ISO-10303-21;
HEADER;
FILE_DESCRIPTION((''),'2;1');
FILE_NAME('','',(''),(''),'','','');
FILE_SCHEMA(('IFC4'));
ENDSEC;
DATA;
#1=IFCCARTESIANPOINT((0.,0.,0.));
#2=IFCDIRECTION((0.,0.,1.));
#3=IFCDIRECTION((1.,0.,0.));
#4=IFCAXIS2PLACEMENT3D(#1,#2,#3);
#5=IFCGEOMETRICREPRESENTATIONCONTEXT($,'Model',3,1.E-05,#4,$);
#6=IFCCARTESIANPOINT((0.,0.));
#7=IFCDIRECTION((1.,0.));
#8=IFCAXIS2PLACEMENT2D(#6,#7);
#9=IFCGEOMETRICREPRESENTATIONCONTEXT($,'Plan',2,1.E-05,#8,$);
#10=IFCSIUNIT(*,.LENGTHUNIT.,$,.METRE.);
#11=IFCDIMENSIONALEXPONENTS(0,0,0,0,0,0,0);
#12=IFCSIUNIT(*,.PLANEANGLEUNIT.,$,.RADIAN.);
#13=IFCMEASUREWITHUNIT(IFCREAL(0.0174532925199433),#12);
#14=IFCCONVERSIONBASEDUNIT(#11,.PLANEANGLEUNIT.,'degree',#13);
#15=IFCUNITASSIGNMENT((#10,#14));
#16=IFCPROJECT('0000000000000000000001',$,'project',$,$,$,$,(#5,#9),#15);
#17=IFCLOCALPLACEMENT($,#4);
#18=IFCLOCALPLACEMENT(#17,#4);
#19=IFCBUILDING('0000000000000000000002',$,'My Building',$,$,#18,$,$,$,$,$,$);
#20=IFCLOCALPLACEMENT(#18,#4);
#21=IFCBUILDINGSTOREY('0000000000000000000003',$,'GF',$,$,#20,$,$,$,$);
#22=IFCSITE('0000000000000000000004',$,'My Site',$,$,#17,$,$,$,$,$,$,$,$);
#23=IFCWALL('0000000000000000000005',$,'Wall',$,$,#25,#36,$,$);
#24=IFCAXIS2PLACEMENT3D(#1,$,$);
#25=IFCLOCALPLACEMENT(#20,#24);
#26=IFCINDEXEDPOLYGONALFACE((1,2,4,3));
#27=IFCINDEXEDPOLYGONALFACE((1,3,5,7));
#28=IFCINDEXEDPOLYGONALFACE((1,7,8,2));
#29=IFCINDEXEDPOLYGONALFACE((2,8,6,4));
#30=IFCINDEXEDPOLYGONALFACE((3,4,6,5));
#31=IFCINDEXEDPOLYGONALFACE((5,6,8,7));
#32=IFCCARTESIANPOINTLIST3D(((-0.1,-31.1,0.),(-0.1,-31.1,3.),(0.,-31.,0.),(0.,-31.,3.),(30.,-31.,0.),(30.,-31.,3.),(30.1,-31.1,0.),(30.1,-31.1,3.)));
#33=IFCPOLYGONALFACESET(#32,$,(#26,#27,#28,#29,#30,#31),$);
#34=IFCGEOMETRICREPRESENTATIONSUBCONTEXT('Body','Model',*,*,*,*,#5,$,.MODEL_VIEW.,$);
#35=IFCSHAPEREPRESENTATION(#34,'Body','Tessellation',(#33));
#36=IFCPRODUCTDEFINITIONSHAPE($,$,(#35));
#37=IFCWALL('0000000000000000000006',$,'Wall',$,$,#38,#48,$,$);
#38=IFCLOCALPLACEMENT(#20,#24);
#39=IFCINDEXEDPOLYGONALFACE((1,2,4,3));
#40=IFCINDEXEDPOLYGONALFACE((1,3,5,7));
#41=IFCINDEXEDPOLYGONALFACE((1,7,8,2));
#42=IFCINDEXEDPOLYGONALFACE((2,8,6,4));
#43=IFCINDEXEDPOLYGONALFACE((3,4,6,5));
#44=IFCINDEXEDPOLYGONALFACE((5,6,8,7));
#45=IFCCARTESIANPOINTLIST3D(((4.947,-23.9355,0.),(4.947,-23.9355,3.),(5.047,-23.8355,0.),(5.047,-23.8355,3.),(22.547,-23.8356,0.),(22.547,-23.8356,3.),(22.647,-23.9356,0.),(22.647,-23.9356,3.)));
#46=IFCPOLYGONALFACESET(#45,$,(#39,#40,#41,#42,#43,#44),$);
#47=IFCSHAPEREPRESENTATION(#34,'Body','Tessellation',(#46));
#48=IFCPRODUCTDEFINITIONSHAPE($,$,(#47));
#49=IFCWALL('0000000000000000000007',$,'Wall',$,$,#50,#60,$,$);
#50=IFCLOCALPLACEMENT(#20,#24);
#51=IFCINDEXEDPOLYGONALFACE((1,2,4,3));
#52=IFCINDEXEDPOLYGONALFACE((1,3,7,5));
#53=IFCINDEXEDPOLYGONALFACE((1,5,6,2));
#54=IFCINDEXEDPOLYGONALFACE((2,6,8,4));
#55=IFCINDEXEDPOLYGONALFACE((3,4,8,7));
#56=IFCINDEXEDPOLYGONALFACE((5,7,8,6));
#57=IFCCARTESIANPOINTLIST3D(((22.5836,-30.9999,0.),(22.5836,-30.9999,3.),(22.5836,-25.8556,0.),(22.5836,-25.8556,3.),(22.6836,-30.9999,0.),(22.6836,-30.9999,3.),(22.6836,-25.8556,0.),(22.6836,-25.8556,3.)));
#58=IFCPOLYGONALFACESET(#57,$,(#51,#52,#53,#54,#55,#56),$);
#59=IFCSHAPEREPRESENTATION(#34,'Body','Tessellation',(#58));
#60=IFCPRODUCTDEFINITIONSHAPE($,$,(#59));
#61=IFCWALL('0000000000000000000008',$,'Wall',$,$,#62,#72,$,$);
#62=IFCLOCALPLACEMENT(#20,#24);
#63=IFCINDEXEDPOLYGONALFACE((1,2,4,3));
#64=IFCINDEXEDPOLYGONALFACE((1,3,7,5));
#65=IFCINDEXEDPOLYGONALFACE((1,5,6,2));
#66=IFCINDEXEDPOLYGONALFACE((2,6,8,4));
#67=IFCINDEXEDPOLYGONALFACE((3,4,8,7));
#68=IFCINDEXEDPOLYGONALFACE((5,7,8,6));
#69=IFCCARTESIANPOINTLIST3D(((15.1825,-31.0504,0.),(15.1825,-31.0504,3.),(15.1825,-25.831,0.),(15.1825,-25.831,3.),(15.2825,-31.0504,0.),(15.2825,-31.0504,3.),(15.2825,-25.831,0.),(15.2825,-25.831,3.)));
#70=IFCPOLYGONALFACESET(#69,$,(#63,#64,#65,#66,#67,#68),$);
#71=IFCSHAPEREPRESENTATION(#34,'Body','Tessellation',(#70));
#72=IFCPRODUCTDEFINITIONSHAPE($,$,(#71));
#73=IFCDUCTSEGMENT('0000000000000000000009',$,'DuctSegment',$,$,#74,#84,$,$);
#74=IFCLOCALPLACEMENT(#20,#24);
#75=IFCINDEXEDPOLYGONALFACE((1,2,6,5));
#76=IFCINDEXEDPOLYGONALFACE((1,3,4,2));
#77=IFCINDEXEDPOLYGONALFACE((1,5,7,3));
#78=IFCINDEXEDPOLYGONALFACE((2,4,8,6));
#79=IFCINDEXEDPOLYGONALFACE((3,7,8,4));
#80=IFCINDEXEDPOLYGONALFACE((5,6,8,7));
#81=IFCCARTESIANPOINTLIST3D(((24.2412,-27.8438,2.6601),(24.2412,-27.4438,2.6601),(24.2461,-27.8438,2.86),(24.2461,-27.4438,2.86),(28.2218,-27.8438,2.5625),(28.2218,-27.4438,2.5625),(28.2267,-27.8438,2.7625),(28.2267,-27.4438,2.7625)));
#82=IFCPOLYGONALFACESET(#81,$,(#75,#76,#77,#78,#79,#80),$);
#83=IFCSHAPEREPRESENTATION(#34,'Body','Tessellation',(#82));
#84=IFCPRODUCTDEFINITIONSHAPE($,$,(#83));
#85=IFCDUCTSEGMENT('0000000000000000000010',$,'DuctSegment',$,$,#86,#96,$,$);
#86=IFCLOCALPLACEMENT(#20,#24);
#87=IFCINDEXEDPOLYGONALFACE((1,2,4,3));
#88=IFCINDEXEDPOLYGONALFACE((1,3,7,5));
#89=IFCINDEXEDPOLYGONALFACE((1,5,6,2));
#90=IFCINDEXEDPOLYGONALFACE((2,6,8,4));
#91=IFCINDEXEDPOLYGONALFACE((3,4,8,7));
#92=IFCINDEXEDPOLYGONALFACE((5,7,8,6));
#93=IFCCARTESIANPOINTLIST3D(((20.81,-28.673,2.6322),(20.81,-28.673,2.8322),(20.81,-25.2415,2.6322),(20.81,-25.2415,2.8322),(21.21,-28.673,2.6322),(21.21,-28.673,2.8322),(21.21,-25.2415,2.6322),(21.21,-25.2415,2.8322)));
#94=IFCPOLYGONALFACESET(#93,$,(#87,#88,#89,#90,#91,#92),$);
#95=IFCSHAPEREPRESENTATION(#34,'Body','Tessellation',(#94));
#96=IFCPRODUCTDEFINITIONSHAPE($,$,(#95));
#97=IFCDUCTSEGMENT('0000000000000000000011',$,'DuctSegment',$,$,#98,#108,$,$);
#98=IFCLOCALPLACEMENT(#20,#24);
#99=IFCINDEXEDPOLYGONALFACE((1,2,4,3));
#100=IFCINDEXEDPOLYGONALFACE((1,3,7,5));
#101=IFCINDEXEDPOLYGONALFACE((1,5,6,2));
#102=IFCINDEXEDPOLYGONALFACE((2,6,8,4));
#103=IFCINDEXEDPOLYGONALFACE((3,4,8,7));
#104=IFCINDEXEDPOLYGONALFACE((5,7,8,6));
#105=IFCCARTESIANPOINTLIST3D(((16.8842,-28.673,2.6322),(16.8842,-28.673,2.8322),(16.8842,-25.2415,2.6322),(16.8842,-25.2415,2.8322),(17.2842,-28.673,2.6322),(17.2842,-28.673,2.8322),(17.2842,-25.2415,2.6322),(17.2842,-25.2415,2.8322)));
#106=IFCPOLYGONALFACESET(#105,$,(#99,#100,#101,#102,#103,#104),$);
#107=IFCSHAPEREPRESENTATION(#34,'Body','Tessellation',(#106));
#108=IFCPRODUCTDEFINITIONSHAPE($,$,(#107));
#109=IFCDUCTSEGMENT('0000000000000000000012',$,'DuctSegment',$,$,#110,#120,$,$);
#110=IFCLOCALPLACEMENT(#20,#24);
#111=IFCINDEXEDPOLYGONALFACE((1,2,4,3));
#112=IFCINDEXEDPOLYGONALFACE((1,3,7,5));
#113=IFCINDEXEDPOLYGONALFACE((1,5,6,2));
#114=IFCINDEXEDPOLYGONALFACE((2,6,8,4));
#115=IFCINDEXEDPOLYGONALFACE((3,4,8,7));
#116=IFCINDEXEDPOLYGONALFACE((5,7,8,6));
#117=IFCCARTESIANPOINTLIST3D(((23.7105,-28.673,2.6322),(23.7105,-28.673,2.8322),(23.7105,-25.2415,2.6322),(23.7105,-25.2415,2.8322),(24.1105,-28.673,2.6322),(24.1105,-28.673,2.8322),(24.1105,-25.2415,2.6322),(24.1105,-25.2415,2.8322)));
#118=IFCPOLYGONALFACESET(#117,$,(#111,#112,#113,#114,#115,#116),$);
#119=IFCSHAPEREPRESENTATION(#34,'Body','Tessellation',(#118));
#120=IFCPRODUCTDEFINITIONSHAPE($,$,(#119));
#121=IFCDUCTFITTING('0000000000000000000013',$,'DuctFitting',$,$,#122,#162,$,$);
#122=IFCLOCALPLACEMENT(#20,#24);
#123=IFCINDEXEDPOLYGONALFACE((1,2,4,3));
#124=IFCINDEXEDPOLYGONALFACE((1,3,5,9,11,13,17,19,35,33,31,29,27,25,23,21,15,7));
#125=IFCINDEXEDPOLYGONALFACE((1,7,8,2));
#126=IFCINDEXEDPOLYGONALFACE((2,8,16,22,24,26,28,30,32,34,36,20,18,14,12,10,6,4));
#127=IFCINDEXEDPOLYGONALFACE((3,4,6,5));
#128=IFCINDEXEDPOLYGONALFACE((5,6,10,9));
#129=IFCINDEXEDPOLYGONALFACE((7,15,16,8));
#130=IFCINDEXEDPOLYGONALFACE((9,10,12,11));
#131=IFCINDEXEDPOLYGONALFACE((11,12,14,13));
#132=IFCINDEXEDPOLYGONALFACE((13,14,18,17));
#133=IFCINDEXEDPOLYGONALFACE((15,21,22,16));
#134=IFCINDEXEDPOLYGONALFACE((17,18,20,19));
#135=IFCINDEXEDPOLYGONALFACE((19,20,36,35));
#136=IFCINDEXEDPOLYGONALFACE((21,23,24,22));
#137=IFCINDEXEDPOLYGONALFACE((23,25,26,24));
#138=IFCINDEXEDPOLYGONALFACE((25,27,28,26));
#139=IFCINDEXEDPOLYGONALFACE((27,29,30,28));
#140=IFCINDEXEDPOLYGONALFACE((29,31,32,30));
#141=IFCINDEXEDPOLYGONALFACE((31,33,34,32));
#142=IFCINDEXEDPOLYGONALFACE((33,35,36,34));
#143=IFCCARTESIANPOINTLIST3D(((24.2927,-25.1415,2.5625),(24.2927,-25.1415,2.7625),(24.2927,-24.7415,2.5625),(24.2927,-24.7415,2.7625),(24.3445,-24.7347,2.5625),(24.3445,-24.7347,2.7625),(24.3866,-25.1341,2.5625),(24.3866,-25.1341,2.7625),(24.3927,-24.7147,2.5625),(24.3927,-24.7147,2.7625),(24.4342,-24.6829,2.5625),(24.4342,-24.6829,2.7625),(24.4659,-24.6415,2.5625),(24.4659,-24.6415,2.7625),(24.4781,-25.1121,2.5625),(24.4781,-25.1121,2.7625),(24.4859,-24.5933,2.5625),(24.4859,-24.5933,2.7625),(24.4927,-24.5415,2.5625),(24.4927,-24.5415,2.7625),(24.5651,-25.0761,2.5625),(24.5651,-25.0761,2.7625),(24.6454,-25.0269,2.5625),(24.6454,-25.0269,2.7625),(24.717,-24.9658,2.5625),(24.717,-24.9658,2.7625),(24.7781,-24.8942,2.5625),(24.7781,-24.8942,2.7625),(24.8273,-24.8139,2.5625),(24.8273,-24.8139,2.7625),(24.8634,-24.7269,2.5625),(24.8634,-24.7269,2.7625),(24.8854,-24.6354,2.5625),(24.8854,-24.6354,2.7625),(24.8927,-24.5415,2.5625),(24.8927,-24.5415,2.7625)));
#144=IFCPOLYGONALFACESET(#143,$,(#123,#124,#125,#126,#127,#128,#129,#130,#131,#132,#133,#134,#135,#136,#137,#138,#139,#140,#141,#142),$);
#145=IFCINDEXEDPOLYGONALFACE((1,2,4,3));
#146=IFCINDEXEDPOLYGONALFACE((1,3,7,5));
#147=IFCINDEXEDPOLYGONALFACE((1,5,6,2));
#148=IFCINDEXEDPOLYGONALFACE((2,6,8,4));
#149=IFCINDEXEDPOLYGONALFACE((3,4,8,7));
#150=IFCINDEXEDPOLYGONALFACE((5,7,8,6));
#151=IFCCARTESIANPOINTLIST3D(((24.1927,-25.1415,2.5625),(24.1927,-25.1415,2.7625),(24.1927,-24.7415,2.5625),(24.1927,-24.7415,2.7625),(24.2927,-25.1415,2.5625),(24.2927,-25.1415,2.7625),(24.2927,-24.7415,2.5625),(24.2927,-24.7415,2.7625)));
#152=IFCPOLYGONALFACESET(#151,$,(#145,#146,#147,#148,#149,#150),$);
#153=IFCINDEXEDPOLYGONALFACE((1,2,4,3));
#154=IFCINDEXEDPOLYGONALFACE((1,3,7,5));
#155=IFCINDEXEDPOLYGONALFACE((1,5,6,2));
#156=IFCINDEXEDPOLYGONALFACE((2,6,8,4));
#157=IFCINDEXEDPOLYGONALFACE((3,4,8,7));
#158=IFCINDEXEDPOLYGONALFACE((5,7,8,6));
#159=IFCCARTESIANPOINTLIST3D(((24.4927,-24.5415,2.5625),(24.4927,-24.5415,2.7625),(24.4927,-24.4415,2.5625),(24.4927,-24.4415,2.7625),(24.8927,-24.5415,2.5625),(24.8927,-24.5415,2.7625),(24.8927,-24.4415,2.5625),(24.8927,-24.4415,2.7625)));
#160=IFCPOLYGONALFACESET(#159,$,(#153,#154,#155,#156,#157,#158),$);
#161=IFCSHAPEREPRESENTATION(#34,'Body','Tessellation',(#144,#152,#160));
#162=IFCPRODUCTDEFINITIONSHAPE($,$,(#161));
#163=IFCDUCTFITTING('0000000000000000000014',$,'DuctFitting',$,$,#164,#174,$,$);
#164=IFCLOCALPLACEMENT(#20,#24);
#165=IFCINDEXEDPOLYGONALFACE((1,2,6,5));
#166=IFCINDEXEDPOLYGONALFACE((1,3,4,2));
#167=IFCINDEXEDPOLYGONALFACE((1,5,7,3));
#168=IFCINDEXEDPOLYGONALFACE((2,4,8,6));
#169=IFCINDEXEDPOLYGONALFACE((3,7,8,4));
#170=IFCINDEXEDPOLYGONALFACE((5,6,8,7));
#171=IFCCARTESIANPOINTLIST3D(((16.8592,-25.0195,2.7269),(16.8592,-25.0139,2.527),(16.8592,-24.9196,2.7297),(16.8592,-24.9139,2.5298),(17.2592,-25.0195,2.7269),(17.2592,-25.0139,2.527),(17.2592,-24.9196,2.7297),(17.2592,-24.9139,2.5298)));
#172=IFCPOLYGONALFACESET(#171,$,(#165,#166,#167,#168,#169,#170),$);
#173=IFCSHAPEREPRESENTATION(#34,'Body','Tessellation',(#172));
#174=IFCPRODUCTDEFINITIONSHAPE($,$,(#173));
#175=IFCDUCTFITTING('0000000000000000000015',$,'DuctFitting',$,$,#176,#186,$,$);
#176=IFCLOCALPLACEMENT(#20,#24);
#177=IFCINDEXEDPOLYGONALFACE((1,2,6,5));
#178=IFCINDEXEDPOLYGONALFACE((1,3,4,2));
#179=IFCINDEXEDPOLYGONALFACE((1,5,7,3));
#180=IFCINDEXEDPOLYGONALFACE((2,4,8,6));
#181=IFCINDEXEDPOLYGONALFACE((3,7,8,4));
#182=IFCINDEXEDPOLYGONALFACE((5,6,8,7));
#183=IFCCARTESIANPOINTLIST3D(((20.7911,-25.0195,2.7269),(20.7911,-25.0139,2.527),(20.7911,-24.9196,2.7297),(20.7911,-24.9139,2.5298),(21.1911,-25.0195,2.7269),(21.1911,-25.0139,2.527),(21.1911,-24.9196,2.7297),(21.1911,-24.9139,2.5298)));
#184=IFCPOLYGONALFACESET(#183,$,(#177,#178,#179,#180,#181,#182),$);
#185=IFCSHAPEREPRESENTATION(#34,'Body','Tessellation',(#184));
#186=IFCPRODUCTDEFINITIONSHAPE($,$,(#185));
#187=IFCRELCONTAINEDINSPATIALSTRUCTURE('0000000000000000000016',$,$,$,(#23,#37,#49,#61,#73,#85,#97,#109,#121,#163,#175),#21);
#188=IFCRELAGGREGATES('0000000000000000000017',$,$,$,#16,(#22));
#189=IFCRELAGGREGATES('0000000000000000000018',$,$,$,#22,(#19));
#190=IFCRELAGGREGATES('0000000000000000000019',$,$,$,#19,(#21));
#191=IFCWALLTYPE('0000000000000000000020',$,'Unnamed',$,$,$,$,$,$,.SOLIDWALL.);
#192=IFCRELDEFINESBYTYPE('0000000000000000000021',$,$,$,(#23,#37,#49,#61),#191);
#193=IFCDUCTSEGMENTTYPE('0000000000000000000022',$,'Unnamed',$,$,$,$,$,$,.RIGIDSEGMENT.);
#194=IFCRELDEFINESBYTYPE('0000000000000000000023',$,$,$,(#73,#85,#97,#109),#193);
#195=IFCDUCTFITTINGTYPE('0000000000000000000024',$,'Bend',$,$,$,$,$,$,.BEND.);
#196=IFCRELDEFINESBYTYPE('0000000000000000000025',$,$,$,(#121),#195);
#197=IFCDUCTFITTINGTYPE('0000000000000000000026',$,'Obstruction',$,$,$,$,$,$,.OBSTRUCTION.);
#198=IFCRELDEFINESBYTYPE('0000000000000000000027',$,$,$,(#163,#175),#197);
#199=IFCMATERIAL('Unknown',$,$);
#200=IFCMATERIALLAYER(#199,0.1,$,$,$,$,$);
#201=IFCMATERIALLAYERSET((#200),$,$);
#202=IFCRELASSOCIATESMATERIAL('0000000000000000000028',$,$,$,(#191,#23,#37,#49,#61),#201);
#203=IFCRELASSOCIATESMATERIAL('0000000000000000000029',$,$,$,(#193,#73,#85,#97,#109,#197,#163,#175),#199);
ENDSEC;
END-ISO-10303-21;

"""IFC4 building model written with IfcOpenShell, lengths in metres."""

from ifc_helpers import new_model, entity, si_unit, converted_unit, frame, origin_with_axes, origin_2d_with_axis, place, context, subcontext, project, spatial, line, arc, indexed_curve, rectangle, outline, extrude, source, transform, mapped, material, layer, layer_set, layer_usage, material_profile, profile_set, profile_usage, type_object, type_shapes, element, save


model = new_model("IFC4")

# Units and contexts
model_context = context("Model", 3, precision=1e-05, world=origin_with_axes())
plan_context = context("Plan", 2, precision=1e-05, world=origin_2d_with_axis())
body_context = subcontext(model_context, "Body", "Model", "MODEL_VIEW")
ifc_project = project(units=[si_unit("LENGTHUNIT", "METRE"), converted_unit("PLANEANGLEUNIT", "degree", entity("IfcReal", 0.0174532925199433), si_unit("PLANEANGLEUNIT", "RADIAN"), dimensions=[0, 0, 0, 0, 0, 0, 0])], contexts=[model_context, plan_context])

# Site, building, storey
site_placement = place(None, origin_with_axes())
site = spatial("IfcSite", under=ifc_project, at=site_placement, Name="My Site")
building_placement = place(site_placement, origin_with_axes())
building = spatial("IfcBuilding", under=site, at=building_placement, Name="My Building")
storey_placement = place(building_placement, origin_with_axes())
storey = spatial("IfcBuildingStorey", under=building, at=storey_placement, Name="GF")

# Walls
ifc_material = material(Name="Unknown")
ifc_layer = layer(ifc_material, 0.1)
ifc_layer_set = layer_set([ifc_layer])
ifc_layer_usage_1 = layer_usage(ifc_layer_set, "AXIS2", "POSITIVE", 0.0)
wall_type = type_object("IfcWallType", Name="Unnamed", PredefinedType="SOLIDWALL", material=ifc_layer_set)
wall_1_placement = place(storey_placement, frame((30.0, -31.0, 0.0), z_axis=(0.0, 0.0, 1.0), x_axis=(-1.0, 0.0, 0.0)))
element("IfcWall", 1, at=wall_1_placement, inside=storey, type_object=wall_type, material=ifc_layer_usage_1, Name="Wall", context=body_context, shape_type="SweptSolid", body=[
    extrude(outline(indexed_curve([(0.0, 0.0), (-0.1, 0.1), (30.1, 0.1), (30.0, 0.0)], segments=[line(1, 2, 3, 4, 1)])), origin_with_axes(), (0.0, 0.0, 1.0), 3.0),
])
ifc_layer_usage_2 = layer_usage(ifc_layer_set, "AXIS2", "POSITIVE", 0.0)
wall_2_placement = place(storey_placement, frame((22.547, -23.8356, 0.0), z_axis=(0.0, 0.0, 1.0), x_axis=(-1.0, 0.0, 0.0)))
element("IfcWall", 2, at=wall_2_placement, inside=storey, type_object=wall_type, material=ifc_layer_usage_2, Name="Wall", context=body_context, shape_type="SweptSolid", body=[
    extrude(outline(indexed_curve([(0.0, 0.0), (-0.1, 0.1), (17.6, 0.1), (17.5, 0.0)], segments=[line(1, 2, 3, 4, 1)])), origin_with_axes(), (0.0, 0.0, 1.0), 3.0),
])
ifc_layer_usage_3 = layer_usage(ifc_layer_set, "AXIS2", "POSITIVE", 0.0)
wall_3_placement = place(storey_placement, frame((22.5836, -25.8556, 0.0), z_axis=(0.0, 0.0, 1.0), x_axis=(0.0, -1.0, 0.0)))
element("IfcWall", 3, at=wall_3_placement, inside=storey, type_object=wall_type, material=ifc_layer_usage_3, Name="Wall", context=body_context, shape_type="SweptSolid", body=[
    extrude(outline(indexed_curve([(0.0, 0.0), (0.0, 0.1), (5.1443, 0.1), (5.1443, 0.0)], segments=[line(1, 2, 3, 4, 1)])), origin_with_axes(), (0.0, 0.0, 1.0), 3.0),
])
ifc_layer_usage_4 = layer_usage(ifc_layer_set, "AXIS2", "POSITIVE", 0.0)
wall_4_placement = place(storey_placement, frame((15.1825, -25.831, 0.0), z_axis=(0.0, 0.0, 1.0), x_axis=(0.0, -1.0, 0.0)))
element("IfcWall", 4, at=wall_4_placement, inside=storey, type_object=wall_type, material=ifc_layer_usage_4, Name="Wall", context=body_context, shape_type="SweptSolid", body=[
    extrude(outline(indexed_curve([(0.0, 0.0), (0.0, 0.1), (5.2194, 0.1), (5.2194, 0.0)], segments=[line(1, 2, 3, 4, 1)])), origin_with_axes(), (0.0, 0.0, 1.0), 3.0),
])

# Duct segments
ifc_material_profile_1 = material_profile(ifc_material, rectangle(XDim=0.4, YDim=0.2))
ifc_profile_set_1 = profile_set([ifc_material_profile_1])
ifc_profile_usage_1 = profile_usage(ifc_profile_set_1, cardinal=5)
duct_segment_type = type_object("IfcDuctSegmentType", Name="Unnamed", PredefinedType="RIGIDSEGMENT", material=ifc_profile_set_1)
duct_segment_1_placement = place(storey_placement, frame((24.2437, -27.6438, 2.7601), z_axis=(0.9997, 0.0, -0.024499), x_axis=(0.0, 1.0, 0.0)))
element("IfcDuctSegment", 5, at=duct_segment_1_placement, inside=storey, type_object=duct_segment_type, material=ifc_profile_usage_1, Name="DuctSegment", context=body_context, shape_type="SweptSolid", body=[
    extrude(rectangle(XDim=0.4, YDim=0.2), origin_with_axes(), (0.0, 0.0, 1.0), 3.9818),
])
ifc_profile_usage_2 = profile_usage(ifc_profile_set_1, cardinal=5)
duct_segment_2_placement = place(storey_placement, frame((21.01, -25.2415, 2.7322), z_axis=(0.0, -1.0, 0.0), x_axis=(1.0, 0.0, 0.0)))
element("IfcDuctSegment", 6, at=duct_segment_2_placement, inside=storey, type_object=duct_segment_type, material=ifc_profile_usage_2, Name="DuctSegment", context=body_context, shape_type="SweptSolid", body=[
    extrude(rectangle(XDim=0.4, YDim=0.2), origin_with_axes(), (0.0, 0.0, 1.0), 3.4315),
])
ifc_profile_usage_3 = profile_usage(ifc_profile_set_1, cardinal=5)
duct_segment_3_placement = place(storey_placement, frame((17.0842, -25.2415, 2.7322), z_axis=(0.0, -1.0, 0.0), x_axis=(1.0, 0.0, 0.0)))
element("IfcDuctSegment", 7, at=duct_segment_3_placement, inside=storey, type_object=duct_segment_type, material=ifc_profile_usage_3, Name="DuctSegment", context=body_context, shape_type="SweptSolid", body=[
    extrude(rectangle(XDim=0.4, YDim=0.2), origin_with_axes(), (0.0, 0.0, 1.0), 3.4315),
])
ifc_profile_usage_4 = profile_usage(ifc_profile_set_1, cardinal=5)
duct_segment_4_placement = place(storey_placement, frame((23.9105, -25.2415, 2.7322), z_axis=(0.0, -1.0, 0.0), x_axis=(1.0, 0.0, 0.0)))
element("IfcDuctSegment", 8, at=duct_segment_4_placement, inside=storey, type_object=duct_segment_type, material=ifc_profile_usage_4, Name="DuctSegment", context=body_context, shape_type="SweptSolid", body=[
    extrude(rectangle(XDim=0.4, YDim=0.2), origin_with_axes(), (0.0, 0.0, 1.0), 3.4315),
])

# Duct fittings
duct_fitting_type_1 = type_object("IfcDuctFittingType", Name="Bend", PredefinedType="BEND")
shared_shape = source(origin_with_axes(), body_context, "Body", "SweptSolid", [
    extrude(outline(indexed_curve([(0.2, 0.0), (0.2586, -0.1414), (0.4, -0.2), (0.4, -0.6), (-0.0243, -0.4243), (-0.2, 0.0)], segments=[arc(1, 2, 3), line(3, 4), arc(4, 5, 6), line(6, 1)])), frame((0.0, -0.1, -0.1), z_axis=(0.0, -1.0, 0.0), x_axis=(1.0, 0.0, 0.0)), (0.0, 0.0, -1.0), 0.2),
    extrude(rectangle(XDim=0.4, YDim=0.2), origin_with_axes(), (0.0, 0.0, -1.0), 0.1),
    extrude(rectangle(XDim=0.4, YDim=0.2), frame((0.4, 0.0, -0.5), z_axis=(1.0, 0.0, 0.0), x_axis=(0.0, 0.0, 1.0)), (0.0, 0.0, 1.0), 0.1),
])
type_shapes(duct_fitting_type_1, [shared_shape])
duct_fitting_1_placement = place(storey_placement, frame((24.1927, -24.9415, 2.6625), z_axis=(-1.0, 0.0, 0.0), x_axis=(0.0, 1.0, 0.0)))
element("IfcDuctFitting", 9, at=duct_fitting_1_placement, inside=storey, type_object=duct_fitting_type_1, Name="DuctFitting", context=body_context, shape_type="MappedRepresentation", body=[
    mapped(shared_shape, transform((0.0, 0.0, 0.0), x_axis=(1.0, 0.0, 0.0), y_axis=(0.0, 1.0, 0.0), z_axis=(0.0, 0.0, 1.0), scale=1.0)),
])
ifc_material_profile_2 = material_profile(ifc_material, rectangle(XDim=0.4, YDim=0.2))
ifc_profile_set_2 = profile_set([ifc_material_profile_2])
ifc_profile_usage_5 = profile_usage(ifc_profile_set_2, cardinal=5)
duct_fitting_type_2 = type_object("IfcDuctFittingType", Name="Obstruction", PredefinedType="OBSTRUCTION", material=ifc_profile_set_2)
duct_fitting_2_placement = place(storey_placement, frame((17.0592, -24.9167, 2.6297), z_axis=(0.0, -0.999605, -0.02812), x_axis=(1.0, 0.0, 0.0)))
element("IfcDuctFitting", 10, at=duct_fitting_2_placement, inside=storey, type_object=duct_fitting_type_2, material=ifc_profile_usage_5, Name="DuctFitting", context=body_context, shape_type="SweptSolid", body=[
    extrude(rectangle(XDim=0.4, YDim=0.2), origin_with_axes(), (0.0, 0.0, 1.0), 0.1),
])
ifc_profile_usage_6 = profile_usage(ifc_profile_set_2, cardinal=5)
duct_fitting_3_placement = place(storey_placement, frame((20.9911, -24.9167, 2.6297), z_axis=(0.0, -0.999605, -0.02812), x_axis=(1.0, 0.0, 0.0)))
element("IfcDuctFitting", 11, at=duct_fitting_3_placement, inside=storey, type_object=duct_fitting_type_2, material=ifc_profile_usage_6, Name="DuctFitting", context=body_context, shape_type="SweptSolid", body=[
    extrude(rectangle(XDim=0.4, YDim=0.2), origin_with_axes(), (0.0, 0.0, 1.0), 0.1),
])

save(model, "model.ifc")
